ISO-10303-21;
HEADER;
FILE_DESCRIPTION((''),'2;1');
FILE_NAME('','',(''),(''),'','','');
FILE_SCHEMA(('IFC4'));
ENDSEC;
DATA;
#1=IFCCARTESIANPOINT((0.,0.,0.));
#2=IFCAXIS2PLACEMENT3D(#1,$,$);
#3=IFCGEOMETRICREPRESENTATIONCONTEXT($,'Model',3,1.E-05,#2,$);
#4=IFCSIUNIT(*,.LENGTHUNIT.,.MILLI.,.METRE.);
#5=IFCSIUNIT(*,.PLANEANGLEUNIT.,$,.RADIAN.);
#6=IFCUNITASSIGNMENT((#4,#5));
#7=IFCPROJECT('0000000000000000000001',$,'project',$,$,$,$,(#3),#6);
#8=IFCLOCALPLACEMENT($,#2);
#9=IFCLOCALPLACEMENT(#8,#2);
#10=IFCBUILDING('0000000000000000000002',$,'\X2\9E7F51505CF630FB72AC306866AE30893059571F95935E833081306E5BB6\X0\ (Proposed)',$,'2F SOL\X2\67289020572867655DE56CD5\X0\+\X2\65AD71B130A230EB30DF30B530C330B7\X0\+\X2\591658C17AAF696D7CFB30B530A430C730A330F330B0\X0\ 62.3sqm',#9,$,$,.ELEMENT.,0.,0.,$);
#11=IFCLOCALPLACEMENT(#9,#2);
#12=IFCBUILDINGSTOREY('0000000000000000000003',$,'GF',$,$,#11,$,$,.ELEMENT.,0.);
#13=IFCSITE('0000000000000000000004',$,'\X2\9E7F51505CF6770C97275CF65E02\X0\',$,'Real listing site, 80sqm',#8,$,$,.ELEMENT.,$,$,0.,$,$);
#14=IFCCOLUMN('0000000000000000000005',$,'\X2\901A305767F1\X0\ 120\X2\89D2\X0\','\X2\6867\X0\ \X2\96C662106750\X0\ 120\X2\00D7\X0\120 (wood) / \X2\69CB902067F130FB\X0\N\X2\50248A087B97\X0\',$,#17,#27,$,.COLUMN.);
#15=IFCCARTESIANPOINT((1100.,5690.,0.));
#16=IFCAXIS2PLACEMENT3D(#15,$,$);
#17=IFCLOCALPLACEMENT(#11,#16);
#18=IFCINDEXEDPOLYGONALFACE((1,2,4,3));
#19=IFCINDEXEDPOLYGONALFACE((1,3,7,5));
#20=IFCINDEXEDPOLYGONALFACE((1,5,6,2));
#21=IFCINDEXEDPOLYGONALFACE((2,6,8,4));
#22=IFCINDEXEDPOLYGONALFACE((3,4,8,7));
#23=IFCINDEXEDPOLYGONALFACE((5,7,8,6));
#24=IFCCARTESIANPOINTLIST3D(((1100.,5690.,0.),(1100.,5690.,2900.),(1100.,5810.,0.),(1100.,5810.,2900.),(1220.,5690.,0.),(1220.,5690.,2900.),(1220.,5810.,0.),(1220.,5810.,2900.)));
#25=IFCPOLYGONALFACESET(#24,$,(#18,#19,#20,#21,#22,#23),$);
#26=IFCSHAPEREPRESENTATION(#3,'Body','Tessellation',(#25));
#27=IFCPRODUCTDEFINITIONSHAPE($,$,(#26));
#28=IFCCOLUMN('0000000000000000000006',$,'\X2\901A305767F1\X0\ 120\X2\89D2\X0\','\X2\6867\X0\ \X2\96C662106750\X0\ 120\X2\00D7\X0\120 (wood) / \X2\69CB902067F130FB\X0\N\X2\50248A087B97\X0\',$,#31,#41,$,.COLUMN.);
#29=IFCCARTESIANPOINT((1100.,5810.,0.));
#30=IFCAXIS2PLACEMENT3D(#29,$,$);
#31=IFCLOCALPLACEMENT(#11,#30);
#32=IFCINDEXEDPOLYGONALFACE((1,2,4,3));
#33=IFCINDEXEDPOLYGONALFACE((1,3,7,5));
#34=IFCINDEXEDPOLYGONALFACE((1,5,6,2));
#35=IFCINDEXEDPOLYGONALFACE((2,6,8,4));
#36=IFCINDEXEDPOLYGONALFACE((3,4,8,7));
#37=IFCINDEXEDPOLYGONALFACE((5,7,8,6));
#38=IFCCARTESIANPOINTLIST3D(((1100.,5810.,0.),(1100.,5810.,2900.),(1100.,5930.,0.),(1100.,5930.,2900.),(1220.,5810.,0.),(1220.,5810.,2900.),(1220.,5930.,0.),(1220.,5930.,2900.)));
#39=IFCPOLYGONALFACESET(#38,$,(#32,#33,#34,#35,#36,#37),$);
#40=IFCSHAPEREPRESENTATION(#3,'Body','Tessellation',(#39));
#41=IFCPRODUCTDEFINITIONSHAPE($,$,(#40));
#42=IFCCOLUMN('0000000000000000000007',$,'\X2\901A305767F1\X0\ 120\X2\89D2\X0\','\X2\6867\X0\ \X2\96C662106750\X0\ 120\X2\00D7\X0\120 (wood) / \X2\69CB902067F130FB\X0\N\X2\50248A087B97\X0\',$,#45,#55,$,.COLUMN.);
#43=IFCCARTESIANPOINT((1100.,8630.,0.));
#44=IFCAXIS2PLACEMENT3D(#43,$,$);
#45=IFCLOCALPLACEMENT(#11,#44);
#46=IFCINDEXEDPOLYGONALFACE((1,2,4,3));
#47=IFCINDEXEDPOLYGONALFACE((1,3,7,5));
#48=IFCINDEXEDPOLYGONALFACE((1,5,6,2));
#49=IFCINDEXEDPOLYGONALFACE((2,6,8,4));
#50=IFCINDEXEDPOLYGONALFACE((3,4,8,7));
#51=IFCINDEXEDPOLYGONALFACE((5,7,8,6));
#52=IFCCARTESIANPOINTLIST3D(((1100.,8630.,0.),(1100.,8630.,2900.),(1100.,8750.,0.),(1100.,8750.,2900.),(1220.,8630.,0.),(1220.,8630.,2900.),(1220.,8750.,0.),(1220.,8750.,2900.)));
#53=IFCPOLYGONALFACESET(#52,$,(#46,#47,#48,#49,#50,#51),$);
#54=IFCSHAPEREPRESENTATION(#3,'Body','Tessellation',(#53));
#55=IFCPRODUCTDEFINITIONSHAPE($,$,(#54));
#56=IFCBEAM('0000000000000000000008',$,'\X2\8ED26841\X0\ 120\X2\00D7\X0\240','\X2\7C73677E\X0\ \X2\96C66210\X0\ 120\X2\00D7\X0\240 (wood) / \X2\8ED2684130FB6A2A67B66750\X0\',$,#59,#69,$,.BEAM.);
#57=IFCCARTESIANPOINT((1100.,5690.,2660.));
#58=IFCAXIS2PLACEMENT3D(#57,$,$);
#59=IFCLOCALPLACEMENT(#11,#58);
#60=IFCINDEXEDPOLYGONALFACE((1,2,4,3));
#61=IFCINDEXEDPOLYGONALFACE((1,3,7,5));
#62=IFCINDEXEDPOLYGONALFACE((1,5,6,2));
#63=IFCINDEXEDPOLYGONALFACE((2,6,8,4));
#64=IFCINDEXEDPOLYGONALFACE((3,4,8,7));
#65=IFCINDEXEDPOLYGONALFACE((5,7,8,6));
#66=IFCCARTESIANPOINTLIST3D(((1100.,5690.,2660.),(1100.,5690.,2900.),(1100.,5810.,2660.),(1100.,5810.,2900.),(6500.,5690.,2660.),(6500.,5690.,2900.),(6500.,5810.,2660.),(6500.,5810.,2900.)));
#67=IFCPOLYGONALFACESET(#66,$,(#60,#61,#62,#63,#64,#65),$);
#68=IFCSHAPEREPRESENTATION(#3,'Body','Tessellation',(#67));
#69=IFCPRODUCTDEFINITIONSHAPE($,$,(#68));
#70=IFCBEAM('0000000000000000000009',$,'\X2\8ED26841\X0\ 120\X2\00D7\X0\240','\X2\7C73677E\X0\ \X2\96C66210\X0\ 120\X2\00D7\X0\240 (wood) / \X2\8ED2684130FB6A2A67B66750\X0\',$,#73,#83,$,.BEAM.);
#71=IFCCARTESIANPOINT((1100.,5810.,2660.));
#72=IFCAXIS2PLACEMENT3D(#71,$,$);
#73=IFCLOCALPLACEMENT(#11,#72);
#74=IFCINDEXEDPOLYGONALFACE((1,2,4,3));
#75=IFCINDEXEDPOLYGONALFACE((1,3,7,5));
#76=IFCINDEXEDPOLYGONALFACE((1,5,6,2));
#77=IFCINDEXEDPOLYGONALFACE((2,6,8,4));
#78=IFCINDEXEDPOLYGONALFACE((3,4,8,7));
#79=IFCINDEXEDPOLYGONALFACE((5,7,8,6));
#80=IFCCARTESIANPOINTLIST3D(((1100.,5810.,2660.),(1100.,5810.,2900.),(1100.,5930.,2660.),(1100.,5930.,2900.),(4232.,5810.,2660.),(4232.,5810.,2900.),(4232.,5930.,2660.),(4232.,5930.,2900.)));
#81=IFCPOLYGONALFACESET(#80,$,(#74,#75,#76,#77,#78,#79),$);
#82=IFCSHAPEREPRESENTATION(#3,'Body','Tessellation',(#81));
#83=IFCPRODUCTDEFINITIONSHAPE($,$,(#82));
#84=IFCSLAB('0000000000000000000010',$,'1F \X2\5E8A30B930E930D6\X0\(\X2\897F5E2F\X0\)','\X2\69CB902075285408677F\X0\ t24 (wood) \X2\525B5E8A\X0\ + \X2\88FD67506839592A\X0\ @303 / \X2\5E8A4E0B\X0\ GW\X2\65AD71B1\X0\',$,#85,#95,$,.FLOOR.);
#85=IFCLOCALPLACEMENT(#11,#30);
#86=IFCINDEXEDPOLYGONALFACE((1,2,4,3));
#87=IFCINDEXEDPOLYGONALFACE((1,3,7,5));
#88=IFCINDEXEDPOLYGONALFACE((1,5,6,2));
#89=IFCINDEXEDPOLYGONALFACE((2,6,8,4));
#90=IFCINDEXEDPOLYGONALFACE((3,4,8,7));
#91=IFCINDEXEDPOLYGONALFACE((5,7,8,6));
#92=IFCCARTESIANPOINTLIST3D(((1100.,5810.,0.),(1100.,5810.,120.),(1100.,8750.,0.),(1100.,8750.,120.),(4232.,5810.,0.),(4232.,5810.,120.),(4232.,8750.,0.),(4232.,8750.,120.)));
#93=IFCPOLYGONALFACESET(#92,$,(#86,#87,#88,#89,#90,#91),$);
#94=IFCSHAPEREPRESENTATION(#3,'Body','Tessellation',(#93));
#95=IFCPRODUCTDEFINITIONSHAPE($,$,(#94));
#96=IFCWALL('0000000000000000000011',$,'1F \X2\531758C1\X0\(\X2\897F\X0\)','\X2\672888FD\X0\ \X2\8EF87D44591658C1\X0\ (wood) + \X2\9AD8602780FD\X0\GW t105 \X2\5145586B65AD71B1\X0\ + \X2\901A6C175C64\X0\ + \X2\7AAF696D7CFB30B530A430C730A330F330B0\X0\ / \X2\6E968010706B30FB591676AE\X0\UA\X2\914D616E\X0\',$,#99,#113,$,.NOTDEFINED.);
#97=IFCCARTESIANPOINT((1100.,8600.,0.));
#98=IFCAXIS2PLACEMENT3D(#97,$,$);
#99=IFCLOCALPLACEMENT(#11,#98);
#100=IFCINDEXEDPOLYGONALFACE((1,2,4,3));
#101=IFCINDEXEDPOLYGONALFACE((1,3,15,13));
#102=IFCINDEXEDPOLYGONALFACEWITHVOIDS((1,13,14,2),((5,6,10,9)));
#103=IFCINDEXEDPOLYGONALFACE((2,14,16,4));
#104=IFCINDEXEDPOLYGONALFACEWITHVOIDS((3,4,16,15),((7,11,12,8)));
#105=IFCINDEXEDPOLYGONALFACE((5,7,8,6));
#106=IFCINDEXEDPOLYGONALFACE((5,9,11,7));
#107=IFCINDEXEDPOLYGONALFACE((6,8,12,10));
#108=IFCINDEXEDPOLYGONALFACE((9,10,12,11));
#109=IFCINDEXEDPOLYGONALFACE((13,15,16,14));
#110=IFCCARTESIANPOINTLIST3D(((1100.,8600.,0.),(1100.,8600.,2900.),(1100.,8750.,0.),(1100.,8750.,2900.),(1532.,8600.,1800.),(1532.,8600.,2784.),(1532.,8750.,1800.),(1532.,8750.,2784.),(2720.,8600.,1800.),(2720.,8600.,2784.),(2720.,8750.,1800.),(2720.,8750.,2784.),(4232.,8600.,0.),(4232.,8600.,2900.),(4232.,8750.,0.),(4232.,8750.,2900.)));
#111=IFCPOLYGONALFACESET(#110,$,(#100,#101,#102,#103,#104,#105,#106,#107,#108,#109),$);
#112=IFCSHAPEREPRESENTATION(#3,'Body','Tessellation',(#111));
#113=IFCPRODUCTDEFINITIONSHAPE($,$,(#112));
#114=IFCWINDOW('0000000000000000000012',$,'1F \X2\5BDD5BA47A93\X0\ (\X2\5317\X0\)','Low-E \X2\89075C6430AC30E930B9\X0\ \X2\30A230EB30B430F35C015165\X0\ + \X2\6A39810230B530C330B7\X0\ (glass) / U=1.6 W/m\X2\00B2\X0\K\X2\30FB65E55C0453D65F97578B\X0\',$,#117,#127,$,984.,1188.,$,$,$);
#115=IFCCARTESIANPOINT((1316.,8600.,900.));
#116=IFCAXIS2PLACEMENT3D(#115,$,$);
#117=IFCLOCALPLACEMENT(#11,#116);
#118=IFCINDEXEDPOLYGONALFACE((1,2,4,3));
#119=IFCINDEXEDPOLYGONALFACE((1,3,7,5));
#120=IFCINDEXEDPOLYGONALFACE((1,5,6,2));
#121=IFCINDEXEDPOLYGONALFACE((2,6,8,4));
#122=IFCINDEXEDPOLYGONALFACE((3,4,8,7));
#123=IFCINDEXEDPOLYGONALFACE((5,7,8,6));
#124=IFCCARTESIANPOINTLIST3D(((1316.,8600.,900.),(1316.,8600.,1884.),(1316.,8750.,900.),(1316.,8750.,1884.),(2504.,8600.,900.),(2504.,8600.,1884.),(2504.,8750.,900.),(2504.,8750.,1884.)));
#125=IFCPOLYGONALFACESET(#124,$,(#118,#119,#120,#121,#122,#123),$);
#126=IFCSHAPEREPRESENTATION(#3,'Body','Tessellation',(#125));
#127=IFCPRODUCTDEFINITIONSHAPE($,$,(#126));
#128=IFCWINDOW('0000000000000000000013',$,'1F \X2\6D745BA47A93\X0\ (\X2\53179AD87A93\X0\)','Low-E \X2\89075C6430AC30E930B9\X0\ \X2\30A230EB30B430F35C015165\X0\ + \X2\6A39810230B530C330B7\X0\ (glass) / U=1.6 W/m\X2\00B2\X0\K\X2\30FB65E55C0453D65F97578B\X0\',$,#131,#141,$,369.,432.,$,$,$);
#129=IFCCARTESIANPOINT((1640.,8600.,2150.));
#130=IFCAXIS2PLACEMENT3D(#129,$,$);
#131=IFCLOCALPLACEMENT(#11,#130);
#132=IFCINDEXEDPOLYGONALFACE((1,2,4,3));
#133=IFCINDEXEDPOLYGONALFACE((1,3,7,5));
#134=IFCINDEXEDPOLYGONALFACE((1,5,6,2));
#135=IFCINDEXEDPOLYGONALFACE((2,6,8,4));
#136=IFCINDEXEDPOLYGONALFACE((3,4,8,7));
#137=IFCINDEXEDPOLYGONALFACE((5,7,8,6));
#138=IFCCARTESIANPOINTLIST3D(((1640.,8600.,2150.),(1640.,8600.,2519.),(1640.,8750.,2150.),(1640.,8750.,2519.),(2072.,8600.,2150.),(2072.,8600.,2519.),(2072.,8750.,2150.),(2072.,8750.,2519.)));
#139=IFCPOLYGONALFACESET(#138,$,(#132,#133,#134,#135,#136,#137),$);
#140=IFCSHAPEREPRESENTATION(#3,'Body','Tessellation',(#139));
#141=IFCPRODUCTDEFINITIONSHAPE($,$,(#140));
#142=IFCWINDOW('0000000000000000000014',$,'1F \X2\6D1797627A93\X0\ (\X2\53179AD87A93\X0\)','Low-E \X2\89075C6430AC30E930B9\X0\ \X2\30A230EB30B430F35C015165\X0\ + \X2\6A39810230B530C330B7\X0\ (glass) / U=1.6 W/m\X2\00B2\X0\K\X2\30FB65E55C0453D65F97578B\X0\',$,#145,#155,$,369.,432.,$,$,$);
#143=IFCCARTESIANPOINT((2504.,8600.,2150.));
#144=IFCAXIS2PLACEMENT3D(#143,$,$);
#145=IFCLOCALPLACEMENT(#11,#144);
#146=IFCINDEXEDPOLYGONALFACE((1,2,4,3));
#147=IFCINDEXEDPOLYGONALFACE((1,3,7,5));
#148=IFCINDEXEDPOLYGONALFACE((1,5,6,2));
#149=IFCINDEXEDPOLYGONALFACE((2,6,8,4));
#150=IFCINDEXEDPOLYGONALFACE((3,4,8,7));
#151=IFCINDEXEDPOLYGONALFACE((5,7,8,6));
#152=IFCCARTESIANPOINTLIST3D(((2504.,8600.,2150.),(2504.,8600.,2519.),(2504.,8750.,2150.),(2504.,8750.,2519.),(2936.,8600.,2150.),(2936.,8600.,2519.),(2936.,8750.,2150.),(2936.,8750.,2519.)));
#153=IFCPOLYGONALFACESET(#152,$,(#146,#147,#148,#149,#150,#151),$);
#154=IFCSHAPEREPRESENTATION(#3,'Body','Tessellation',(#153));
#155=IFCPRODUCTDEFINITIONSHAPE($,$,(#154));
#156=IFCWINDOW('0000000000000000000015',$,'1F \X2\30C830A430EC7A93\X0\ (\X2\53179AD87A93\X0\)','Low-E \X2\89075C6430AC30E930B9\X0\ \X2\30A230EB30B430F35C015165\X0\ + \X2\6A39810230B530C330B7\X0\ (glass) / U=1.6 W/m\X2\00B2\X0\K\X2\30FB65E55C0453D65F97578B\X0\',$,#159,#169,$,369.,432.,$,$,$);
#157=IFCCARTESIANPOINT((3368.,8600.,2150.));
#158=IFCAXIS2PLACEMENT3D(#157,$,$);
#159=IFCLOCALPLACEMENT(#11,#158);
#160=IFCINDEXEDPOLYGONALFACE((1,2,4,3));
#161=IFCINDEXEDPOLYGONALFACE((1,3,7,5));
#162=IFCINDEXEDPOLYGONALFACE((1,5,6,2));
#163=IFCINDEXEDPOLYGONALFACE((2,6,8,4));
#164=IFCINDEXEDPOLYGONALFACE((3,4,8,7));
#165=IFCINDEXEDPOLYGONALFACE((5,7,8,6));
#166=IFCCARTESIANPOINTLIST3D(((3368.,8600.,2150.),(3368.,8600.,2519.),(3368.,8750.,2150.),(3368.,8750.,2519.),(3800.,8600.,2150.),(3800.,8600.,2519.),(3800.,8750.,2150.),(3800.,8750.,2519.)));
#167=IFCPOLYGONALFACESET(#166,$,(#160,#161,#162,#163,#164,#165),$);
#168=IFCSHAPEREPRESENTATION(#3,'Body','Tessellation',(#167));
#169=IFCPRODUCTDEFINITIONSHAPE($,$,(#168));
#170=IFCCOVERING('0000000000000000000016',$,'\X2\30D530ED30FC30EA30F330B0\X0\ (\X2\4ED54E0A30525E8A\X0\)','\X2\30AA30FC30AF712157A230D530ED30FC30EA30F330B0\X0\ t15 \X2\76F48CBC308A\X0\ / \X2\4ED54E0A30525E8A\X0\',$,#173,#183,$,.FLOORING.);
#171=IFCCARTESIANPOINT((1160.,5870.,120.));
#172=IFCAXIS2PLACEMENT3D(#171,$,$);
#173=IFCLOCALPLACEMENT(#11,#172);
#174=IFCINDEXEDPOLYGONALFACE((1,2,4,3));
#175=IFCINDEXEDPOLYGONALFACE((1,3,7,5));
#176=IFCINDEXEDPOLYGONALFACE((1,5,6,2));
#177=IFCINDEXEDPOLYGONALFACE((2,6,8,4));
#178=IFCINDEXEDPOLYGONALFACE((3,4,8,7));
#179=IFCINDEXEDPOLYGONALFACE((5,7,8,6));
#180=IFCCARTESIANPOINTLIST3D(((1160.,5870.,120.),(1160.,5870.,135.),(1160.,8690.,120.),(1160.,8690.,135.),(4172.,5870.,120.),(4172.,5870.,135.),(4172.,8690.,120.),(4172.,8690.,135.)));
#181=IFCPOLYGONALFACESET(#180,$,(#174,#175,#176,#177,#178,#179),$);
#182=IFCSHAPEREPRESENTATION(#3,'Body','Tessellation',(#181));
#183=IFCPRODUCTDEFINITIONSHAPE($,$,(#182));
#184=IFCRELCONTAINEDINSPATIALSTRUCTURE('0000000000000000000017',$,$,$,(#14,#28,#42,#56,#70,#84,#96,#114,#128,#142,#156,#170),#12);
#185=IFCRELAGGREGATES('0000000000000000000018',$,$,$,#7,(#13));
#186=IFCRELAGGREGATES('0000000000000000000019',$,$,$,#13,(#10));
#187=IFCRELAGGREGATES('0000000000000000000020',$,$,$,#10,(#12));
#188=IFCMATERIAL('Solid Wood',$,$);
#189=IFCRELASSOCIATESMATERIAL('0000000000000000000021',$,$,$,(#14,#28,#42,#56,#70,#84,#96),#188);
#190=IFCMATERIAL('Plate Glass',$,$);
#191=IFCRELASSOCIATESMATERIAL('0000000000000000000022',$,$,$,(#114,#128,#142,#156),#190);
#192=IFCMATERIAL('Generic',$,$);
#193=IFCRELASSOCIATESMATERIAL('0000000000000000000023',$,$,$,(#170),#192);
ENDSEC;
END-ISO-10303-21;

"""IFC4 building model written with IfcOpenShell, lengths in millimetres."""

from ifc_helpers import new_model, si_unit, frame, frame_2d, origin, place, context, project, spatial, rectangle, extrude, material, element, fill, save


model = new_model("IFC4")

# Units and contexts
model_context = context("Model", 3, precision=1e-05, world=origin())
ifc_project = project(units=[si_unit("LENGTHUNIT", "METRE", prefix="MILLI"), si_unit("PLANEANGLEUNIT", "RADIAN")], contexts=[model_context])

# Site, building, storey
site_placement = place(None, origin())
site = spatial("IfcSite", under=ifc_project, at=site_placement, Name="鹿児島県霧島市", ObjectType="Real listing site, 80sqm", CompositionType="ELEMENT", RefElevation=0.0)
building_placement = place(site_placement, origin())
building = spatial("IfcBuilding", under=site, at=building_placement, Name="鹿児島・犬と暮らす土間広めの家 (Proposed)", ObjectType="2F SOL木造在来工法+断熱アルミサッシ+外壁窯業系サイディング 62.3sqm", CompositionType="ELEMENT", ElevationOfRefHeight=0.0, ElevationOfTerrain=0.0)
storey_placement = place(building_placement, origin())
storey = spatial("IfcBuildingStorey", under=building, at=storey_placement, Name="GF", CompositionType="ELEMENT", Elevation=0.0)

# Columns
ifc_material_1 = material(Name="Solid Wood")
column_1_placement = place(storey_placement, frame((1100.0, 5690.0, 0.0)))
element("IfcColumn", 1, at=column_1_placement, inside=storey, material=ifc_material_1, Name="通し柱 120角", Description="桧 集成材 120×120 (wood) / 構造柱・N値計算", PredefinedType="COLUMN", context=model_context, shape_type="SweptSolid", body=[
    extrude(rectangle(XDim=120.0, YDim=120.0, at=frame_2d((60.0, 60.0))), frame((1100.0, 5690.0, 0.0)), (0.0, 0.0, 1.0), 2900.0),
])
column_2_placement = place(storey_placement, frame((1100.0, 5810.0, 0.0)))
element("IfcColumn", 2, at=column_2_placement, inside=storey, material=ifc_material_1, Name="通し柱 120角", Description="桧 集成材 120×120 (wood) / 構造柱・N値計算", PredefinedType="COLUMN", context=model_context, shape_type="SweptSolid", body=[
    extrude(rectangle(XDim=120.0, YDim=120.0, at=frame_2d((60.0, 60.0))), frame((1100.0, 5810.0, 0.0)), (0.0, 0.0, 1.0), 2900.0),
])
column_3_placement = place(storey_placement, frame((1100.0, 8630.0, 0.0)))
element("IfcColumn", 3, at=column_3_placement, inside=storey, material=ifc_material_1, Name="通し柱 120角", Description="桧 集成材 120×120 (wood) / 構造柱・N値計算", PredefinedType="COLUMN", context=model_context, shape_type="SweptSolid", body=[
    extrude(rectangle(XDim=120.0, YDim=120.0, at=frame_2d((60.0, 60.0))), frame((1100.0, 8630.0, 0.0)), (0.0, 0.0, 1.0), 2900.0),
])

# Beams
beam_1_placement = place(storey_placement, frame((1100.0, 5690.0, 2660.0)))
element("IfcBeam", 4, at=beam_1_placement, inside=storey, material=ifc_material_1, Name="軒桁 120×240", Description="米松 集成 120×240 (wood) / 軒桁・横架材", PredefinedType="BEAM", context=model_context, shape_type="SweptSolid", body=[
    extrude(rectangle(XDim=5400.0, YDim=120.0, at=frame_2d((2700.0, 60.0))), frame((1100.0, 5690.0, 2660.0)), (0.0, 0.0, 1.0), 240.0),
])
beam_2_placement = place(storey_placement, frame((1100.0, 5810.0, 2660.0)))
element("IfcBeam", 5, at=beam_2_placement, inside=storey, material=ifc_material_1, Name="軒桁 120×240", Description="米松 集成 120×240 (wood) / 軒桁・横架材", PredefinedType="BEAM", context=model_context, shape_type="SweptSolid", body=[
    extrude(rectangle(XDim=3132.0, YDim=120.0, at=frame_2d((1566.0, 60.0))), frame((1100.0, 5810.0, 2660.0)), (0.0, 0.0, 1.0), 240.0),
])

# Slab
slab_placement = place(storey_placement, frame((1100.0, 5810.0, 0.0)))
element("IfcSlab", 6, at=slab_placement, inside=storey, material=ifc_material_1, Name="1F 床スラブ(西帯)", Description="構造用合板 t24 (wood) 剛床 + 製材根太 @303 / 床下 GW断熱", PredefinedType="FLOOR", context=model_context, shape_type="SweptSolid", body=[
    extrude(rectangle(XDim=3132.0, YDim=2940.0, at=frame_2d((1566.0, 1470.0))), frame((1100.0, 5810.0, 0.0)), (0.0, 0.0, 1.0), 120.0),
])

# Wall, openings, windows
wall_1_placement = place(storey_placement, frame((1100.0, 8600.0, 0.0)))
wall_1 = element("IfcWall", 7, at=wall_1_placement, inside=storey, material=ifc_material_1, Name="1F 北壁(西)", Description="木製 軸組外壁 (wood) + 高性能GW t105 充填断熱 + 通気層 + 窯業系サイディング / 準耐火・外皮UA配慮", PredefinedType="NOTDEFINED", context=model_context, shape_type="SweptSolid", body=[
    extrude(rectangle(XDim=3132.0, YDim=150.0, at=frame_2d((1566.0, 75.0))), frame((1100.0, 8600.0, 0.0)), (0.0, 0.0, 1.0), 2900.0),
])
opening_1_placement = place(storey_placement, frame((1316.0, 8600.0, 900.0)))
opening_1 = element("IfcOpeningElement", 8, at=opening_1_placement, cuts=wall_1, PredefinedType="NOTDEFINED", context=model_context, shape_type="SweptSolid", body=[
    extrude(rectangle(XDim=1188.0, YDim=150.0, at=frame_2d((594.0, 75.0))), frame((1316.0, 8600.0, 900.0)), (0.0, 0.0, 1.0), 984.0),
])
opening_2_placement = place(storey_placement, frame((1640.0, 8600.0, 2150.0)))
opening_2 = element("IfcOpeningElement", 9, at=opening_2_placement, cuts=wall_1, PredefinedType="NOTDEFINED", context=model_context, shape_type="SweptSolid", body=[
    extrude(rectangle(XDim=432.0, YDim=150.0, at=frame_2d((216.0, 75.0))), frame((1640.0, 8600.0, 2150.0)), (0.0, 0.0, 1.0), 369.0),
])
opening_3_placement = place(storey_placement, frame((2504.0, 8600.0, 2150.0)))
opening_3 = element("IfcOpeningElement", 10, at=opening_3_placement, cuts=wall_1, PredefinedType="NOTDEFINED", context=model_context, shape_type="SweptSolid", body=[
    extrude(rectangle(XDim=432.0, YDim=150.0, at=frame_2d((216.0, 75.0))), frame((2504.0, 8600.0, 2150.0)), (0.0, 0.0, 1.0), 369.0),
])
opening_4_placement = place(storey_placement, frame((3368.0, 8600.0, 2150.0)))
opening_4 = element("IfcOpeningElement", 11, at=opening_4_placement, cuts=wall_1, PredefinedType="NOTDEFINED", context=model_context, shape_type="SweptSolid", body=[
    extrude(rectangle(XDim=432.0, YDim=150.0, at=frame_2d((216.0, 75.0))), frame((3368.0, 8600.0, 2150.0)), (0.0, 0.0, 1.0), 369.0),
])
ifc_material_2 = material(Name="Plate Glass")
window_1_placement = place(storey_placement, frame((1316.0, 8600.0, 900.0)))
window_1 = element("IfcWindow", 12, at=window_1_placement, inside=storey, material=ifc_material_2, Name="1F 寝室窓 (北)", Description="Low-E 複層ガラス アルゴン封入 + 樹脂サッシ (glass) / U=1.6 W/m²K・日射取得型", OverallHeight=984.0, OverallWidth=1188.0, context=model_context, shape_type="SweptSolid", body=[
    extrude(rectangle(XDim=1188.0, YDim=150.0, at=frame_2d((594.0, 75.0))), frame((1316.0, 8600.0, 900.0)), (0.0, 0.0, 1.0), 984.0),
])
fill(opening_1, window_1)
window_2_placement = place(storey_placement, frame((1640.0, 8600.0, 2150.0)))
window_2 = element("IfcWindow", 13, at=window_2_placement, inside=storey, material=ifc_material_2, Name="1F 浴室窓 (北高窓)", Description="Low-E 複層ガラス アルゴン封入 + 樹脂サッシ (glass) / U=1.6 W/m²K・日射取得型", OverallHeight=369.0, OverallWidth=432.0, context=model_context, shape_type="SweptSolid", body=[
    extrude(rectangle(XDim=432.0, YDim=150.0, at=frame_2d((216.0, 75.0))), frame((1640.0, 8600.0, 2150.0)), (0.0, 0.0, 1.0), 369.0),
])
fill(opening_2, window_2)
window_3_placement = place(storey_placement, frame((2504.0, 8600.0, 2150.0)))
window_3 = element("IfcWindow", 14, at=window_3_placement, inside=storey, material=ifc_material_2, Name="1F 洗面窓 (北高窓)", Description="Low-E 複層ガラス アルゴン封入 + 樹脂サッシ (glass) / U=1.6 W/m²K・日射取得型", OverallHeight=369.0, OverallWidth=432.0, context=model_context, shape_type="SweptSolid", body=[
    extrude(rectangle(XDim=432.0, YDim=150.0, at=frame_2d((216.0, 75.0))), frame((2504.0, 8600.0, 2150.0)), (0.0, 0.0, 1.0), 369.0),
])
fill(opening_3, window_3)
window_4_placement = place(storey_placement, frame((3368.0, 8600.0, 2150.0)))
window_4 = element("IfcWindow", 15, at=window_4_placement, inside=storey, material=ifc_material_2, Name="1F トイレ窓 (北高窓)", Description="Low-E 複層ガラス アルゴン封入 + 樹脂サッシ (glass) / U=1.6 W/m²K・日射取得型", OverallHeight=369.0, OverallWidth=432.0, context=model_context, shape_type="SweptSolid", body=[
    extrude(rectangle(XDim=432.0, YDim=150.0, at=frame_2d((216.0, 75.0))), frame((3368.0, 8600.0, 2150.0)), (0.0, 0.0, 1.0), 369.0),
])
fill(opening_4, window_4)

# Covering
ifc_material_3 = material(Name="Generic")
covering_placement = place(storey_placement, frame((1160.0, 5870.0, 120.0)))
element("IfcCovering", 16, at=covering_placement, inside=storey, material=ifc_material_3, Name="フローリング (仕上げ床)", Description="オーク無垢フローリング t15 直貼り / 仕上げ床", PredefinedType="FLOORING", context=model_context, shape_type="SweptSolid", body=[
    extrude(rectangle(XDim=3012.0, YDim=2820.0, at=frame_2d((1506.0, 1410.0))), frame((1160.0, 5870.0, 120.0)), (0.0, 0.0, 1.0), 15.0),
])

save(model, "model.ifc")
